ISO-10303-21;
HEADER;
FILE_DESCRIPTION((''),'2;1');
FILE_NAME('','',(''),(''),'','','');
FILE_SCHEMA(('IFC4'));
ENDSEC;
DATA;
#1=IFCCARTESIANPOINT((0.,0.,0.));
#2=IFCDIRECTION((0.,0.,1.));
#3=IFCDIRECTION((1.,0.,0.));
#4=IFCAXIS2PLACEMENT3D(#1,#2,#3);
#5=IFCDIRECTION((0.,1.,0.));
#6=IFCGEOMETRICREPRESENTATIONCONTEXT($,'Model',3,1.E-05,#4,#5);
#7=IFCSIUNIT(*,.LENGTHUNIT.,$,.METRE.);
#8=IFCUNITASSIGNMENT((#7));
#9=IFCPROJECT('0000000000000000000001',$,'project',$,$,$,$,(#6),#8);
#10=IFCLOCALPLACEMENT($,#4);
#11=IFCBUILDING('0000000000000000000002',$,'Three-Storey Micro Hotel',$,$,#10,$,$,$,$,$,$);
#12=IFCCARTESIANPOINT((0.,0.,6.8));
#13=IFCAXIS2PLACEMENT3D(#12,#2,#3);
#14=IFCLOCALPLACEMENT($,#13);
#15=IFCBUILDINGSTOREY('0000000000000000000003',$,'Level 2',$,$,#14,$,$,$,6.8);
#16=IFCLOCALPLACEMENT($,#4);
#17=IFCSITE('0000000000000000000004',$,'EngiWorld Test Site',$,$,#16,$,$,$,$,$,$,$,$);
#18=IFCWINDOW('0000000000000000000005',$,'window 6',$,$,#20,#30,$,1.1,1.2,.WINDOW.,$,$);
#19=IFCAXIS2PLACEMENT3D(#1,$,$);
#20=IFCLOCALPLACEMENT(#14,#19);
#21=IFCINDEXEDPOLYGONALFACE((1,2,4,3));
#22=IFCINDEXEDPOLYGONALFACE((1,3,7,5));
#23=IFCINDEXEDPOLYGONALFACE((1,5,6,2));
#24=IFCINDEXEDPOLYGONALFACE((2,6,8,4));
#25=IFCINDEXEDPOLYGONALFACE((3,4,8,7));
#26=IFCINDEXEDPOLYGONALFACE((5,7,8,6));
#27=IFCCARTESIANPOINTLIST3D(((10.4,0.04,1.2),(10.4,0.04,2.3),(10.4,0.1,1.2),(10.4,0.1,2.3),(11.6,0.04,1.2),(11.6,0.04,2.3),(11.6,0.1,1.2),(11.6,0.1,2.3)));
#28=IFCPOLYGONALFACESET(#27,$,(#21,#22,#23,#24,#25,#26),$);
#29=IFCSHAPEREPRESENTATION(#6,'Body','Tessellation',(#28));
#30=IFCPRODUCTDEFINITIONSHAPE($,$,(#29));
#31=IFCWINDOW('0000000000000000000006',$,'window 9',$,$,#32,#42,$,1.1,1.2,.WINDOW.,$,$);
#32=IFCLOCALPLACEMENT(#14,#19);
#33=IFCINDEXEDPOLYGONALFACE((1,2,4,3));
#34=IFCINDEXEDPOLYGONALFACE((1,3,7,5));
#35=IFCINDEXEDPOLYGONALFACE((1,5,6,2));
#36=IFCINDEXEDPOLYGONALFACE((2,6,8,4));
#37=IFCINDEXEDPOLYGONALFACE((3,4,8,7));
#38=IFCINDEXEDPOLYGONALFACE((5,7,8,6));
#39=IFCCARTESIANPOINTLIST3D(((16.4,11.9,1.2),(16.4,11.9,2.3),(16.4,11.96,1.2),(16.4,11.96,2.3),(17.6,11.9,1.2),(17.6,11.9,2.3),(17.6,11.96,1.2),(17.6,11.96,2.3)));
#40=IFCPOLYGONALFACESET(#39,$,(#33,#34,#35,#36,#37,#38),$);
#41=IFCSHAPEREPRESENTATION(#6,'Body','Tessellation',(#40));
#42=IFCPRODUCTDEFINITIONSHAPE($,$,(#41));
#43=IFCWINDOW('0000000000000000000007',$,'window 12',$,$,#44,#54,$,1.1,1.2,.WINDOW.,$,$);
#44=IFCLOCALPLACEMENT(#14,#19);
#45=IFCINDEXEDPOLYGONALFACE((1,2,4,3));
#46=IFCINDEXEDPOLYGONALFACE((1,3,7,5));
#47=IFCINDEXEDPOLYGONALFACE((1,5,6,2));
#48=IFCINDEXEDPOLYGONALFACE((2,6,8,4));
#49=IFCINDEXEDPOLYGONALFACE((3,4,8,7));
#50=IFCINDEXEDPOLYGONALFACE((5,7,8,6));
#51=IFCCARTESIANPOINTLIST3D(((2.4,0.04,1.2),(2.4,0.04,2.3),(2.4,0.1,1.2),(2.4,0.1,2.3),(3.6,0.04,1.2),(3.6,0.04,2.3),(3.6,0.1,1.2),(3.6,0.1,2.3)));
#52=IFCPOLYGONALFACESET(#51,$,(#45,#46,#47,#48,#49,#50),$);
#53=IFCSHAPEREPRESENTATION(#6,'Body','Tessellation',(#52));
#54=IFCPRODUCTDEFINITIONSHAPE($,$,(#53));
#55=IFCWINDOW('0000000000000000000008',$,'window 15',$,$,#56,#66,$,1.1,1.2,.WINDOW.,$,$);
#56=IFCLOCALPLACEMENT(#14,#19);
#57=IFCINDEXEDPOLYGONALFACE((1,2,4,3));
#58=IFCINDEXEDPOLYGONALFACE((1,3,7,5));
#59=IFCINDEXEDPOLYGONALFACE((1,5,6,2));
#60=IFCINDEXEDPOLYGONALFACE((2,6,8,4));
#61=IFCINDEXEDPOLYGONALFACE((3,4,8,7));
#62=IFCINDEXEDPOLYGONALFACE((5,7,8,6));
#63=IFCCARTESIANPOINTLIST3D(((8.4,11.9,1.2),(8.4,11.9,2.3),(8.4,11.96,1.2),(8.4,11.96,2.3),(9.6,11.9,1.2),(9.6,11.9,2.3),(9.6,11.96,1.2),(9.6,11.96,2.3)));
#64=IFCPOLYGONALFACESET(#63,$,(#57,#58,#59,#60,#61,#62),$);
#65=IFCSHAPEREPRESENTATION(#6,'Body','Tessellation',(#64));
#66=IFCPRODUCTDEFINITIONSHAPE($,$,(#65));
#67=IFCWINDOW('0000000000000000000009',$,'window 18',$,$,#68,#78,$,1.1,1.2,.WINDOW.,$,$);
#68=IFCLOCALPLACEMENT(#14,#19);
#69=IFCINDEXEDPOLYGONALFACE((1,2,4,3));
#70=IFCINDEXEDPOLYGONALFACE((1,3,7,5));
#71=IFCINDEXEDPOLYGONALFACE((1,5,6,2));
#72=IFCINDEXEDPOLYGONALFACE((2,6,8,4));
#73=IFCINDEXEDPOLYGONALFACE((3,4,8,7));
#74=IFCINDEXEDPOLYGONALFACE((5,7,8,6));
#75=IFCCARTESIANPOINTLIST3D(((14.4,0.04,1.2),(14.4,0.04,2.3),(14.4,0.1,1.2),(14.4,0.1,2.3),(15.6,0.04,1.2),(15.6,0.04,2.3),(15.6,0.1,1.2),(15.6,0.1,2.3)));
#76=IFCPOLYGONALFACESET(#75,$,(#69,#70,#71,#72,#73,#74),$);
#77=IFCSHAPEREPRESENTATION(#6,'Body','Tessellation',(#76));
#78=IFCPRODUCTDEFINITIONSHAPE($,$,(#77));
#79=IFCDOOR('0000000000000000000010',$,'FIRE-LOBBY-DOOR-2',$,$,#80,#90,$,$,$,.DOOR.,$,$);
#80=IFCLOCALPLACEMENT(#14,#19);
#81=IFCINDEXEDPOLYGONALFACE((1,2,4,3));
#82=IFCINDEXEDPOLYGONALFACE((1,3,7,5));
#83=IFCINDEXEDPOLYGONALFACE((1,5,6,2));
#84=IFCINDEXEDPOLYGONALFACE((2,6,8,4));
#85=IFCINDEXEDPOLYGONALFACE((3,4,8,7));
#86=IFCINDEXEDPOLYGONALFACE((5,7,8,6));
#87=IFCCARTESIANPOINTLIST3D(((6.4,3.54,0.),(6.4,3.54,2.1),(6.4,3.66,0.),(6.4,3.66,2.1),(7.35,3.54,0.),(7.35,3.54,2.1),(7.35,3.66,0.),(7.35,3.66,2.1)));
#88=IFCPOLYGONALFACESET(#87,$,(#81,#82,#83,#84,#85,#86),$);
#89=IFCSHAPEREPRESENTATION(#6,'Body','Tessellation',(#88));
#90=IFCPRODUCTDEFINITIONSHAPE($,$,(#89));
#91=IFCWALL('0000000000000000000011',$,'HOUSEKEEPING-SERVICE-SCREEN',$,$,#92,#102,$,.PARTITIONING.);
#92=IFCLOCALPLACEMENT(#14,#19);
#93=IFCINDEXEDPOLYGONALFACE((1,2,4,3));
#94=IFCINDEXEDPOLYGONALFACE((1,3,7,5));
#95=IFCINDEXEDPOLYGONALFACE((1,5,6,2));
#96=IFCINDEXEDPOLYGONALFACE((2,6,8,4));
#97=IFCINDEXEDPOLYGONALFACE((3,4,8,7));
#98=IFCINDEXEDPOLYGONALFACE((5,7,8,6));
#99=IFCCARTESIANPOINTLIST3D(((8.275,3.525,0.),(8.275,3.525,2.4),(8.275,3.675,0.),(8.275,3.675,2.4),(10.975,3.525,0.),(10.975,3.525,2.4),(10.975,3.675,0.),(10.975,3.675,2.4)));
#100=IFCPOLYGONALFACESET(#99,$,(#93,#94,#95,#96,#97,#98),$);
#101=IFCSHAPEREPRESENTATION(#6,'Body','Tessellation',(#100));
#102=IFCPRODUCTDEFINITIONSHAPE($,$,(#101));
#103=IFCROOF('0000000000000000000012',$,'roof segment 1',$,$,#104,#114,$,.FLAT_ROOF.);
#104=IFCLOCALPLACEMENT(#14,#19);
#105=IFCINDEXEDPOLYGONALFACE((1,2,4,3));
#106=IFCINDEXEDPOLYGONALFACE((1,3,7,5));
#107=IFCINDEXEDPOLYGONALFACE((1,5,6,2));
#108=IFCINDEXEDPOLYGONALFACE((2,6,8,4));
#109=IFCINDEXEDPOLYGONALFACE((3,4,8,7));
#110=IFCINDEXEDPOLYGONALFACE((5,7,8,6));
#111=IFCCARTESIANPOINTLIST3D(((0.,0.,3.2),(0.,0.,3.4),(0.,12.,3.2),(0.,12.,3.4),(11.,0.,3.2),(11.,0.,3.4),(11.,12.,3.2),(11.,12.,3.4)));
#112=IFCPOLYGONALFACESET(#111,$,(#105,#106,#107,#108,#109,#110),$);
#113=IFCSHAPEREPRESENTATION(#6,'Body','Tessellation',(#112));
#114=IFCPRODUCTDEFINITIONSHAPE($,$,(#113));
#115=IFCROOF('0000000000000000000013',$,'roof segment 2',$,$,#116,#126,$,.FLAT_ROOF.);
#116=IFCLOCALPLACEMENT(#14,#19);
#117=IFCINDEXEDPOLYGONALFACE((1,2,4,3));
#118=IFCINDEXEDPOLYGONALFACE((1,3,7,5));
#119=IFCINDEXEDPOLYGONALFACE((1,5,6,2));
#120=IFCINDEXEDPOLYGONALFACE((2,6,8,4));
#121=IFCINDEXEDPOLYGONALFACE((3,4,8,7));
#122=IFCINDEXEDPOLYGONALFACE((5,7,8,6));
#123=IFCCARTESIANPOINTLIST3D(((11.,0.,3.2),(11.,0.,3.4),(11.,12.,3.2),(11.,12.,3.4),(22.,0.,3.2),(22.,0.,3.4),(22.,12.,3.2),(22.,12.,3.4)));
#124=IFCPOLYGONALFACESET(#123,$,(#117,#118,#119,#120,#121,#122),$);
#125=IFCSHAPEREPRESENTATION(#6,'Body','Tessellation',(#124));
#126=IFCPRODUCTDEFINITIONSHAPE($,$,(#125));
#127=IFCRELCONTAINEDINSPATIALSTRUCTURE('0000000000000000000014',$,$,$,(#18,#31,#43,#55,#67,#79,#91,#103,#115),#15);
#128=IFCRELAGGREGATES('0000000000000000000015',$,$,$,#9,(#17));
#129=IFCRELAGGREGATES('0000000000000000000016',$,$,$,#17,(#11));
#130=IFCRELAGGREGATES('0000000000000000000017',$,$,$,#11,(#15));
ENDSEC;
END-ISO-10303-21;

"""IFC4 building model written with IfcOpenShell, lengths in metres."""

from ifc_helpers import new_model, si_unit, direction, frame, origin, origin_with_axes, origin_2d, origin_2d_with_axis, place, context, project, spatial, rectangle, extrude, element, save


model = new_model("IFC4")

# Units and contexts
model_context = context("Model", 3, precision=1e-05, world=origin_with_axes(), true_north=direction((0.0, 1.0, 0.0)))
ifc_project = project(units=[si_unit("LENGTHUNIT", "METRE")], contexts=[model_context])

# Site, building, storey
site_placement = place(None, origin_with_axes())
site = spatial("IfcSite", under=ifc_project, at=site_placement, Name="EngiWorld Test Site")
building_placement = place(None, origin_with_axes())
building = spatial("IfcBuilding", under=site, at=building_placement, Name="Three-Storey Micro Hotel")
storey_placement = place(None, frame((0.0, 0.0, 6.8), z_axis=(0.0, 0.0, 1.0), x_axis=(1.0, 0.0, 0.0)))
storey = spatial("IfcBuildingStorey", under=building, at=storey_placement, Name="Level 2", Elevation=6.8)

# Windows
for number, where, z_axis, x_axis, name in (
    (1, (11.0, 0.07, 8.0), (0.0, 0.0, 1.0), (1.0, 0.0, 0.0), "window 6"),
    (2, (17.0, 11.93, 8.0), (0.0, 0.0, 1.0), (1.0, 0.0, 0.0), "window 9"),
    (3, (3.0, 0.07, 8.0), (0.0, 0.0, 1.0), (1.0, 0.0, 0.0), "window 12"),
    (4, (9.0, 11.93, 8.0), (0.0, 0.0, 1.0), (1.0, 0.0, 0.0), "window 15"),
    (5, (15.0, 0.07, 8.0), (0.0, 0.0, 1.0), (1.0, 0.0, 0.0), "window 18"),
):
    element("IfcWindow", number, at=place(None, frame(where, z_axis=z_axis, x_axis=x_axis)), inside=storey, Name=name, OverallHeight=1.1, OverallWidth=1.2, PredefinedType="WINDOW", context=model_context, shape_type="SweptSolid", body=[
        extrude(rectangle(XDim=1.2, YDim=0.06, at=origin_2d_with_axis()), origin_with_axes(), (0.0, 0.0, 1.0), 1.1),
    ])

# Door
door_placement = place(None, frame((6.875, 3.6, 6.8)))
element("IfcDoor", 6, at=door_placement, inside=storey, Name="FIRE-LOBBY-DOOR-2", PredefinedType="DOOR", context=model_context, shape_type="SweptSolid", body=[
    extrude(rectangle(XDim=0.95, YDim=0.12, at=origin_2d()), origin(), (0.0, 0.0, 1.0), 2.1),
])

# Wall
wall_1_placement = place(None, frame((9.625, 3.6, 6.8)))
element("IfcWall", 7, at=wall_1_placement, inside=storey, Name="HOUSEKEEPING-SERVICE-SCREEN", PredefinedType="PARTITIONING", context=model_context, shape_type="SweptSolid", body=[
    extrude(rectangle(XDim=2.7, YDim=0.15, at=origin_2d()), origin(), (0.0, 0.0, 1.0), 2.4),
])

# Roofs
for number, where, z_axis, x_axis, name in (
    (8, (5.5, 6.0, 10.0), (0.0, 0.0, 1.0), (1.0, 0.0, 0.0), "roof segment 1"),
    (9, (16.5, 6.0, 10.0), (0.0, 0.0, 1.0), (1.0, 0.0, 0.0), "roof segment 2"),
):
    element("IfcRoof", number, at=place(None, frame(where, z_axis=z_axis, x_axis=x_axis)), inside=storey, Name=name, PredefinedType="FLAT_ROOF", context=model_context, shape_type="SweptSolid", body=[
        extrude(rectangle(XDim=11.0, YDim=12.0, at=origin_2d_with_axis()), origin_with_axes(), (0.0, 0.0, 1.0), 0.2),
    ])

save(model, "model.ifc")
